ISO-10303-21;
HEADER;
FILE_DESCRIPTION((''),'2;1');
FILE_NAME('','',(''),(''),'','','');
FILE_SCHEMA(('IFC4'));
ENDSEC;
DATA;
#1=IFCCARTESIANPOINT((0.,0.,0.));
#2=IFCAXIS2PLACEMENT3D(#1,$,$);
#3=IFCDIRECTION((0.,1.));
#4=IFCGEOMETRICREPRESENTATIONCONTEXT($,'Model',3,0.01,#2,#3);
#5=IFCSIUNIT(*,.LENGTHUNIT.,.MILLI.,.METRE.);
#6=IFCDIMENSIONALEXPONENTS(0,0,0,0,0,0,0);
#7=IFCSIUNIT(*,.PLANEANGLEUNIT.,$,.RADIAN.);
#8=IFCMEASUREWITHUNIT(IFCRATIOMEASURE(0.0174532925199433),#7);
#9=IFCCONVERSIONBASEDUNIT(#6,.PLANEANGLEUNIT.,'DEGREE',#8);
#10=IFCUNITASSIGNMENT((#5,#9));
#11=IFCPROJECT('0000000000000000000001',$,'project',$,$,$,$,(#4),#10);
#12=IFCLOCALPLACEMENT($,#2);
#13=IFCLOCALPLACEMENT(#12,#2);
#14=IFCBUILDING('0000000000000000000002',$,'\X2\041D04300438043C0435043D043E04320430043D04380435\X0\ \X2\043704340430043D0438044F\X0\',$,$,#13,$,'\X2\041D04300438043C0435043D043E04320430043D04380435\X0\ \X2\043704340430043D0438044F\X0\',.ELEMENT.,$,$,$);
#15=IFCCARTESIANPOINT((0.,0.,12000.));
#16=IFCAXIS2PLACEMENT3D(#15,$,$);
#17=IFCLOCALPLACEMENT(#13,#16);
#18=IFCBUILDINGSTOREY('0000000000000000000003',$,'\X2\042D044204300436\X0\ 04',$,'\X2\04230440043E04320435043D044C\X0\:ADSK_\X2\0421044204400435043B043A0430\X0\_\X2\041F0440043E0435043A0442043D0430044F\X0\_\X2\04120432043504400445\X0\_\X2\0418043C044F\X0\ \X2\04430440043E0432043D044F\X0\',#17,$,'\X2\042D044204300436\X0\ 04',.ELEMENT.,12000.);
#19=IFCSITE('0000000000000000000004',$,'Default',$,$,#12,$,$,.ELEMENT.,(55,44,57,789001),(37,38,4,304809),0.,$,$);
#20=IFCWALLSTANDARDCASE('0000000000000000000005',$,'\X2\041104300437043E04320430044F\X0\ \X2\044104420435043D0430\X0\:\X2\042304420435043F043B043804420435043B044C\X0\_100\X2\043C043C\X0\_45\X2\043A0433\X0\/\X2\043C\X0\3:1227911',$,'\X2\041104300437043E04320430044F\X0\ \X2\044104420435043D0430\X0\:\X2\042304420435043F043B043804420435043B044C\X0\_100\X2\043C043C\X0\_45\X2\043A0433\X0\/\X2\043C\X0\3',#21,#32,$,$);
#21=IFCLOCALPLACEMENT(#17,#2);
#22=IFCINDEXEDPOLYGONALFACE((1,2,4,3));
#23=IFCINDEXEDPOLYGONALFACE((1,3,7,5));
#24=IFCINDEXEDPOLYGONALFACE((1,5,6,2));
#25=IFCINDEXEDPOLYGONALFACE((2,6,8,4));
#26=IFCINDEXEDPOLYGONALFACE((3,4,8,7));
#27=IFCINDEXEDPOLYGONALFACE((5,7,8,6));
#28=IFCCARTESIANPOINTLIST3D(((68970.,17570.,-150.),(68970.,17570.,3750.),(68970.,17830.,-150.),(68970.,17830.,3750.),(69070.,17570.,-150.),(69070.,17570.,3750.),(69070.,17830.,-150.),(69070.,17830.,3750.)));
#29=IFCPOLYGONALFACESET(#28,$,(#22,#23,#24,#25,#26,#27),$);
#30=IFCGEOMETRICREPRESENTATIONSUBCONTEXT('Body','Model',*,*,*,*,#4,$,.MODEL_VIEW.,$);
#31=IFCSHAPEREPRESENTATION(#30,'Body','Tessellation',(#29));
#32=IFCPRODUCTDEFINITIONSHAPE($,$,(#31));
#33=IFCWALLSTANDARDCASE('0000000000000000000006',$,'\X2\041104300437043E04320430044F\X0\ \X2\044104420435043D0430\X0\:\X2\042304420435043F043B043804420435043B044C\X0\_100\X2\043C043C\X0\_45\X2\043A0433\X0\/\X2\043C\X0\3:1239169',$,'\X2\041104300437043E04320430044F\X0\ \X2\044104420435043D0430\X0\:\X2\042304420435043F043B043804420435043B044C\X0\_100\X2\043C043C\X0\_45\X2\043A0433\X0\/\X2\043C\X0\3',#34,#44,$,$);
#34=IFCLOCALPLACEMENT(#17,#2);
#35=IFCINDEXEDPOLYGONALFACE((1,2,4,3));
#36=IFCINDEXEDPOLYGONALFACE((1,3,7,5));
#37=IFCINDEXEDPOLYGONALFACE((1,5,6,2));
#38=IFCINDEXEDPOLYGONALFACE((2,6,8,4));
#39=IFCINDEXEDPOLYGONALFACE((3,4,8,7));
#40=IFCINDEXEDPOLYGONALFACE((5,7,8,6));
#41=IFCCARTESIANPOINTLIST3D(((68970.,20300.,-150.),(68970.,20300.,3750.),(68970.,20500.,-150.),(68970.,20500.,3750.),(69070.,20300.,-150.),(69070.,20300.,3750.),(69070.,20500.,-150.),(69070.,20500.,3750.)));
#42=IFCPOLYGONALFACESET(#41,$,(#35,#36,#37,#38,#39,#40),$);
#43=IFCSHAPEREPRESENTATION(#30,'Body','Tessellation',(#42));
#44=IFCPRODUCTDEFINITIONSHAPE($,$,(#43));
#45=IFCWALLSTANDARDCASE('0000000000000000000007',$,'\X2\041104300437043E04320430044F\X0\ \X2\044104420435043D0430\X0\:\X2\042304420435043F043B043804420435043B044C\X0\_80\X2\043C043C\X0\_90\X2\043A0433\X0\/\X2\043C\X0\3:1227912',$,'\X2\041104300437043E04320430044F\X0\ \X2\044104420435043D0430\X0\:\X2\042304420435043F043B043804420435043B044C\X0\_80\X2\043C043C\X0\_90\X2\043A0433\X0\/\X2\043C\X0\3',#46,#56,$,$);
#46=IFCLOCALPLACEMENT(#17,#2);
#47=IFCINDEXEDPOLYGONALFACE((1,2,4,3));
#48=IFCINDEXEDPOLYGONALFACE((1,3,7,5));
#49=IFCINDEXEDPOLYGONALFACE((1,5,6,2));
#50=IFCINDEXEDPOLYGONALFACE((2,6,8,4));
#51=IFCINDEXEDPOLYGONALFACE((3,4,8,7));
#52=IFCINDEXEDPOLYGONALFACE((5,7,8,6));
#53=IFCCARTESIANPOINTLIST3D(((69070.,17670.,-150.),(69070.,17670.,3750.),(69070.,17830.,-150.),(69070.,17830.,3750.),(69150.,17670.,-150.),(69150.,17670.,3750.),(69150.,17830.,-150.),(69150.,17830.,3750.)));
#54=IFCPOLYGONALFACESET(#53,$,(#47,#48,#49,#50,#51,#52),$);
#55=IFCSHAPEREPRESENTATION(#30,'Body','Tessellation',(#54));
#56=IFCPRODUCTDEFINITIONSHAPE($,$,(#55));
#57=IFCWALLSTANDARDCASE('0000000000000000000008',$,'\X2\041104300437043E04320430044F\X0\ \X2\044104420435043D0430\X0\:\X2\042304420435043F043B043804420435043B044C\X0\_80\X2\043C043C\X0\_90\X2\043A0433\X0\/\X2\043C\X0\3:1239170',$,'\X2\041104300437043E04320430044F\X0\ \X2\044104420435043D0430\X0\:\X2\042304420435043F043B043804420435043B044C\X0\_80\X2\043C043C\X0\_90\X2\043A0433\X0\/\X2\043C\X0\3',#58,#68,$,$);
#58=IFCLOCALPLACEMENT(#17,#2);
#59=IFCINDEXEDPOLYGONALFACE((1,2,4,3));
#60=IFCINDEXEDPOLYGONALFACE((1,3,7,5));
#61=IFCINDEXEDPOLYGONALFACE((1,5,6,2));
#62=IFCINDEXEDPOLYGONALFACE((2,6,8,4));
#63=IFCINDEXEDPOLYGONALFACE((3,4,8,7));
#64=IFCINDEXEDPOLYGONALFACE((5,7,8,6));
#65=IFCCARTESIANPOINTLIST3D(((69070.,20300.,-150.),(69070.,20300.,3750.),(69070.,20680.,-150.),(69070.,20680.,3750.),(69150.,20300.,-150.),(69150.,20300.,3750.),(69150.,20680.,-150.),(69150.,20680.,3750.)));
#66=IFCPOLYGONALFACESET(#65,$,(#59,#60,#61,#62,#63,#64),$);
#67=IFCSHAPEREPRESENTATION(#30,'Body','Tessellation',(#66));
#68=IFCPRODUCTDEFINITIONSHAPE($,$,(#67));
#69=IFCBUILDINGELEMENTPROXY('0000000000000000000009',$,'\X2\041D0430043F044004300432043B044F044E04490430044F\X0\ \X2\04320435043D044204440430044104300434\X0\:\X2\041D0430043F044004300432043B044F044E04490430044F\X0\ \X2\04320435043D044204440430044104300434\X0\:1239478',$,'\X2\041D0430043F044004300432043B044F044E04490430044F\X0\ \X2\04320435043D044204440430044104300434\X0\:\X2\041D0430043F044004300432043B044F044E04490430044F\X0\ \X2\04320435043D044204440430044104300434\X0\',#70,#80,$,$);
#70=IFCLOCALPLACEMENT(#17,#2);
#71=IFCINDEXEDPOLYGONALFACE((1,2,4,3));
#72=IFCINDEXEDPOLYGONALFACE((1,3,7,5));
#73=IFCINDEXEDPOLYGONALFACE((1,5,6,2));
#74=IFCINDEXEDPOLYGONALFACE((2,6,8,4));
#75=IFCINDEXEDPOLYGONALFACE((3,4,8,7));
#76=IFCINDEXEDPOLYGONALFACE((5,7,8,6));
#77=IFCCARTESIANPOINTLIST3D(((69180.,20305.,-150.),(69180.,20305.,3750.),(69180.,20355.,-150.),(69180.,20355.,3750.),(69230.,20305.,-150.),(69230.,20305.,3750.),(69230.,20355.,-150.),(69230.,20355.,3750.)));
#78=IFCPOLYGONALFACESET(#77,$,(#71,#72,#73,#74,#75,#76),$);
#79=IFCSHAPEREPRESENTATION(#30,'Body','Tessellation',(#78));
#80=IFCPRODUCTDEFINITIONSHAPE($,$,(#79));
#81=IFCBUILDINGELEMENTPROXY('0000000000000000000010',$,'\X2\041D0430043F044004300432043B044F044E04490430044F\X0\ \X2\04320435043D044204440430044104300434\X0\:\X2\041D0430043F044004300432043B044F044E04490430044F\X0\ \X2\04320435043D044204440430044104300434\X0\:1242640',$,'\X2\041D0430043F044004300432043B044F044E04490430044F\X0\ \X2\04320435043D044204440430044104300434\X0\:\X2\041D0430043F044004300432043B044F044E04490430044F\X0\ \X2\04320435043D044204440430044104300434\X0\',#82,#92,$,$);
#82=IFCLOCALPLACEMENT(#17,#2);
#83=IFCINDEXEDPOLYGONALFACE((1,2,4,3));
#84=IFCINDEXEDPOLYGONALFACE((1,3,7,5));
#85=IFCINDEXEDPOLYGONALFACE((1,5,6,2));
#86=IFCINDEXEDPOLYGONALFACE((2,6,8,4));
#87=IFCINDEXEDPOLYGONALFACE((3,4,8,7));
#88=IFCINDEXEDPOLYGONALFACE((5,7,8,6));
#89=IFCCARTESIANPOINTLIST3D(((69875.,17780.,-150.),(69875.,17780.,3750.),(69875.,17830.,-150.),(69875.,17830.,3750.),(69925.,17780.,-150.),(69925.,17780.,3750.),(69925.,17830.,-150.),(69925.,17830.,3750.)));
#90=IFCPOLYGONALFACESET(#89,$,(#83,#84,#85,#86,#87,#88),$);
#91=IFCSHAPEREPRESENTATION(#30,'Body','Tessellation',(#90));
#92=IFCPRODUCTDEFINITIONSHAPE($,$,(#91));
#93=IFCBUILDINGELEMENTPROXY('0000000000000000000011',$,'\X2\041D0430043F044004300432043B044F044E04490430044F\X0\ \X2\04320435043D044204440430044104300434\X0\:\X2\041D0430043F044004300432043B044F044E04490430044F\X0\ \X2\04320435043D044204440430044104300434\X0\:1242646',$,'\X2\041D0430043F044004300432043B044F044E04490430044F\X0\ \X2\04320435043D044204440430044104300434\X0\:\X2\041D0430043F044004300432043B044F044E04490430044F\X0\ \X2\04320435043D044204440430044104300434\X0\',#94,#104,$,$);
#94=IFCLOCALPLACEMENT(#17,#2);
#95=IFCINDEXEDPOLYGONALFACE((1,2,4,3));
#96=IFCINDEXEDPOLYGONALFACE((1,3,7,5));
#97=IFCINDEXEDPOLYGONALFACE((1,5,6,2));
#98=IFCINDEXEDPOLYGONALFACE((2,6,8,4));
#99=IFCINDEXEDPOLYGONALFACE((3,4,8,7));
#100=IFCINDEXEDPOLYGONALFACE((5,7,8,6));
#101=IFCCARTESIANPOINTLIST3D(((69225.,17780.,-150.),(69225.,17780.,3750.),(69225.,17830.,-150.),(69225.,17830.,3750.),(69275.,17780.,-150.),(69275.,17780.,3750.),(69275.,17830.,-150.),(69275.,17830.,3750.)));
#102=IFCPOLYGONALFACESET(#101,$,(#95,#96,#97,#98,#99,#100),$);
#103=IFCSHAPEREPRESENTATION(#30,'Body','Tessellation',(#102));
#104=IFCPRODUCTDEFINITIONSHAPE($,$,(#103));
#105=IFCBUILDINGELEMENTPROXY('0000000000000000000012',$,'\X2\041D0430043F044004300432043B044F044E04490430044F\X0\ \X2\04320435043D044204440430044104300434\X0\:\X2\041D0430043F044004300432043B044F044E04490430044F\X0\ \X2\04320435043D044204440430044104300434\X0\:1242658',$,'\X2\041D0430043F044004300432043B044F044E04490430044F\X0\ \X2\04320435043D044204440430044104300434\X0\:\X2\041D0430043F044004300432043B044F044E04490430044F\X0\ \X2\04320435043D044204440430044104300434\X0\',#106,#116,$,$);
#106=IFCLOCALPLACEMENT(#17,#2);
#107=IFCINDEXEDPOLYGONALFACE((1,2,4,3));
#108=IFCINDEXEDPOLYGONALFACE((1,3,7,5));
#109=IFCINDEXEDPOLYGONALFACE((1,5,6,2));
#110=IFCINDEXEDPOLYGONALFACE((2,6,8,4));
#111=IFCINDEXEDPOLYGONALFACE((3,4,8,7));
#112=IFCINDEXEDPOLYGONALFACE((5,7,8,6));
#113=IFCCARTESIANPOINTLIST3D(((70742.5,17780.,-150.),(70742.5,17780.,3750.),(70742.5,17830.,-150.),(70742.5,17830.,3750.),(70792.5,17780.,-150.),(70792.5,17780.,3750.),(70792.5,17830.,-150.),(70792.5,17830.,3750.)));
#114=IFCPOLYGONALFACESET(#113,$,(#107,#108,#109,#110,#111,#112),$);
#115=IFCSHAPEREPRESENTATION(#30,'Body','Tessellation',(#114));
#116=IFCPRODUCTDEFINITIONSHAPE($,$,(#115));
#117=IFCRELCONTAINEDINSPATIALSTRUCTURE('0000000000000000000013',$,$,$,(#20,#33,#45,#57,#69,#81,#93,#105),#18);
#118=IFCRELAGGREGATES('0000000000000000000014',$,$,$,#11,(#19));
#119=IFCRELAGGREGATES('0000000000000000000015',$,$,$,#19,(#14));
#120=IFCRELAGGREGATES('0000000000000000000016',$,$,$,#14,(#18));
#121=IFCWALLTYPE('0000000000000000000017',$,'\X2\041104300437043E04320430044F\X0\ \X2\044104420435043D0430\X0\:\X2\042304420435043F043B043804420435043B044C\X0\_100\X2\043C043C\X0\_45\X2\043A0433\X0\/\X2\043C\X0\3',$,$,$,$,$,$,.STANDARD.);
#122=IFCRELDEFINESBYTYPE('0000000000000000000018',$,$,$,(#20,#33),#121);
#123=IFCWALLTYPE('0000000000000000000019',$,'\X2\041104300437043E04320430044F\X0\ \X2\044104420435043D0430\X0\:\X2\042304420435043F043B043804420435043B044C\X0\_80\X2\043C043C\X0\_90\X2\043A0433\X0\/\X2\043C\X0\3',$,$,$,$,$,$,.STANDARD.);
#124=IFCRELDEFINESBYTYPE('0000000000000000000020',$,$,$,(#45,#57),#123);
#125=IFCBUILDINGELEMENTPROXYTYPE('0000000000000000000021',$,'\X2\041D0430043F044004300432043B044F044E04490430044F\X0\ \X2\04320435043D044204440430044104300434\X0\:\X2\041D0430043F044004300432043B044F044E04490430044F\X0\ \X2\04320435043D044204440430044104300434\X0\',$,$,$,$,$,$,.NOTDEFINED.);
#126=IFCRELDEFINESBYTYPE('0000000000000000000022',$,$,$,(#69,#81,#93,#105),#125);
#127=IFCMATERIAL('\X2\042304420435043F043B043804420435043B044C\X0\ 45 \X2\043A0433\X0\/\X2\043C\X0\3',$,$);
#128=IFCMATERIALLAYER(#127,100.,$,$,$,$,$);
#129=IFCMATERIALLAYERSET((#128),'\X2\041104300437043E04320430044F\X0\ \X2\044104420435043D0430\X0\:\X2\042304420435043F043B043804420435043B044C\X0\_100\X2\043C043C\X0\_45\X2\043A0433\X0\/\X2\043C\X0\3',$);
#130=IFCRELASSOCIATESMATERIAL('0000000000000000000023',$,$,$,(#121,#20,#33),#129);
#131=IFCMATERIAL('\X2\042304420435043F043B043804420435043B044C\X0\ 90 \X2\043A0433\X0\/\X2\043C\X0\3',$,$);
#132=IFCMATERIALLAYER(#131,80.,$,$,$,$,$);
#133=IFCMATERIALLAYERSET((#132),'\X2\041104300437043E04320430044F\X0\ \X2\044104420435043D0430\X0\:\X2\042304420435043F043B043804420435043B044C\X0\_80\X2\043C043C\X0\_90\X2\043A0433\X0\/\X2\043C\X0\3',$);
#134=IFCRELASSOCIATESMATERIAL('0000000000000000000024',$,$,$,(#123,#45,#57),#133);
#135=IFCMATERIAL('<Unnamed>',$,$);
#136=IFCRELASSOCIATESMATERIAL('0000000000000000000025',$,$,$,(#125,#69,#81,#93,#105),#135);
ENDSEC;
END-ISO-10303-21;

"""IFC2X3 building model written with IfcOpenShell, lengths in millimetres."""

from ifc_helpers import new_model, entity, si_unit, converted_unit, direction, frame, frame_2d, origin, origin_2d_with_axis, place, context, subcontext, project, spatial, rectangle, extrude, source, transform, mapped, material, layer, layer_set, layer_usage, type_object, type_shapes, element, save


model = new_model("IFC2X3")

# Units and contexts
model_context = context("Model", 3, precision=0.01, world=origin(), true_north=direction((0.0, 1.0)))
body_context = subcontext(model_context, "Body", "Model", "MODEL_VIEW")
ifc_project = project(units=[si_unit("LENGTHUNIT", "METRE", prefix="MILLI"), converted_unit("PLANEANGLEUNIT", "DEGREE", entity("IfcRatioMeasure", 0.0174532925199433), si_unit("PLANEANGLEUNIT", "RADIAN"), dimensions=[0, 0, 0, 0, 0, 0, 0])], contexts=[model_context])

# Site, building, storey
site_placement = place(None, origin())
site = spatial("IfcSite", under=ifc_project, at=site_placement, Name="Default", CompositionType="ELEMENT", RefLatitude=(55, 44, 57, 789001), RefLongitude=(37, 38, 4, 304809), RefElevation=0.0)
building_placement = place(site_placement, origin())
building = spatial("IfcBuilding", under=site, at=building_placement, Name="Наименование здания", LongName="Наименование здания", CompositionType="ELEMENT")
storey_placement = place(building_placement, frame((0.0, 0.0, 12000.0)))
storey = spatial("IfcBuildingStorey", under=building, at=storey_placement, Name="Этаж 04", ObjectType="Уровень:ADSK_Стрелка_Проектная_Вверх_Имя уровня", LongName="Этаж 04", CompositionType="ELEMENT", Elevation=12000.0)

# Walls
ifc_material_1 = material(Name="Утеплитель 45 кг/м3")
ifc_layer_1 = layer(ifc_material_1, 100.0)
ifc_layer_set_1 = layer_set([ifc_layer_1], Name="Базовая стена:Утеплитель_100мм_45кг/м3")
ifc_layer_usage_1 = layer_usage(ifc_layer_set_1, "AXIS2", "NEGATIVE", 50.0)
wall_type_1 = type_object("IfcWallType", Name="Базовая стена:Утеплитель_100мм_45кг/м3", PredefinedType="STANDARD", material=ifc_layer_set_1)
wall_1_placement = place(storey_placement, frame((69020.0, 17830.0, -150.0), z_axis=(0.0, 0.0, 1.0), x_axis=(0.0, -1.0, 0.0)))
element("IfcWallStandardCase", 1, at=wall_1_placement, inside=storey, type_object=wall_type_1, material=ifc_layer_usage_1, Name="Базовая стена:Утеплитель_100мм_45кг/м3:1227911", ObjectType="Базовая стена:Утеплитель_100мм_45кг/м3", context=body_context, shape_type="SweptSolid", body=[
    extrude(rectangle(XDim=260.0, YDim=100.0, at=frame_2d((130.0, 0.0), x_axis=(-1.0, 0.0))), origin(), (0.0, 0.0, 1.0), 3900.0),
])
ifc_layer_usage_2 = layer_usage(ifc_layer_set_1, "AXIS2", "POSITIVE", -50.0)
wall_2_placement = place(storey_placement, frame((69020.0, 20300.0, -150.0), z_axis=(0.0, 0.0, 1.0), x_axis=(0.0, 1.0, 0.0)))
element("IfcWallStandardCase", 2, at=wall_2_placement, inside=storey, type_object=wall_type_1, material=ifc_layer_usage_2, Name="Базовая стена:Утеплитель_100мм_45кг/м3:1239169", ObjectType="Базовая стена:Утеплитель_100мм_45кг/м3", context=body_context, shape_type="SweptSolid", body=[
    extrude(rectangle(XDim=200.0, YDim=100.0, at=frame_2d((100.0, 0.0), x_axis=(-1.0, 0.0))), origin(), (0.0, 0.0, 1.0), 3900.0),
])
ifc_material_2 = material(Name="Утеплитель 90 кг/м3")
ifc_layer_2 = layer(ifc_material_2, 80.0)
ifc_layer_set_2 = layer_set([ifc_layer_2], Name="Базовая стена:Утеплитель_80мм_90кг/м3")
ifc_layer_usage_3 = layer_usage(ifc_layer_set_2, "AXIS2", "NEGATIVE", 40.0)
wall_type_2 = type_object("IfcWallType", Name="Базовая стена:Утеплитель_80мм_90кг/м3", PredefinedType="STANDARD", material=ifc_layer_set_2)
wall_3_placement = place(storey_placement, frame((69110.0, 17830.0, -150.0), z_axis=(0.0, 0.0, 1.0), x_axis=(0.0, -1.0, 0.0)))
element("IfcWallStandardCase", 3, at=wall_3_placement, inside=storey, type_object=wall_type_2, material=ifc_layer_usage_3, Name="Базовая стена:Утеплитель_80мм_90кг/м3:1227912", ObjectType="Базовая стена:Утеплитель_80мм_90кг/м3", context=body_context, shape_type="SweptSolid", body=[
    extrude(rectangle(XDim=160.0, YDim=80.0, at=frame_2d((80.0, 0.0), x_axis=(-1.0, 0.0))), origin(), (0.0, 0.0, 1.0), 3900.0),
])
ifc_layer_usage_4 = layer_usage(ifc_layer_set_2, "AXIS2", "POSITIVE", -40.0)
wall_4_placement = place(storey_placement, frame((69110.0, 20300.0, -150.0), z_axis=(0.0, 0.0, 1.0), x_axis=(0.0, 1.0, 0.0)))
element("IfcWallStandardCase", 4, at=wall_4_placement, inside=storey, type_object=wall_type_2, material=ifc_layer_usage_4, Name="Базовая стена:Утеплитель_80мм_90кг/м3:1239170", ObjectType="Базовая стена:Утеплитель_80мм_90кг/м3", context=body_context, shape_type="SweptSolid", body=[
    extrude(rectangle(XDim=380.0, YDim=80.0, at=frame_2d((190.0, 0.0), x_axis=(-1.0, 0.0))), origin(), (0.0, 0.0, 1.0), 3900.0),
])

# Building element proxies
ifc_material_3 = material(Name="<Unnamed>")
building_element_proxy_type_1 = type_object("IfcBuildingElementProxyType", Name="Направляющая вентфасад:Направляющая вентфасад", PredefinedType="NOTDEFINED", material=ifc_material_3)
shared_shape_1 = source(origin(), body_context, "Body", "SweptSolid", [
    extrude(rectangle(XDim=50.0, YDim=50.0, at=origin_2d_with_axis()), frame((25.0, -25.0, 0.0), z_axis=(0.0, 0.0, 1.0), x_axis=(-1.0, 0.0, 0.0)), (0.0, 0.0, 1.0), 3900.0),
])
type_shapes(building_element_proxy_type_1, [shared_shape_1])
for number, where, z_axis, x_axis, name in (
    (5, (69180.0, 20305.0, -150.0), (0.0, 0.0, 1.0), (0.0, 1.0, 0.0), "Направляющая вентфасад:Направляющая вентфасад:1239478"),
    (6, (69925.0, 17780.0, -150.0), (0.0, 0.0, 1.0), (-1.0, 0.0, 0.0), "Направляющая вентфасад:Направляющая вентфасад:1242640"),
    (7, (69275.0, 17780.0, -150.0), (0.0, 0.0, 1.0), (-1.0, 0.0, 0.0), "Направляющая вентфасад:Направляющая вентфасад:1242646"),
    (8, (70792.5, 17780.0, -150.0), (0.0, 0.0, 1.0), (-1.0, 0.0, 0.0), "Направляющая вентфасад:Направляющая вентфасад:1242658"),
):
    element("IfcBuildingElementProxy", number, at=place(storey_placement, frame(where, z_axis=z_axis, x_axis=x_axis)), inside=storey, type_object=building_element_proxy_type_1, material=ifc_material_3, Name=name, ObjectType="Направляющая вентфасад:Направляющая вентфасад", context=body_context, shape_type="MappedRepresentation", body=[
        mapped(shared_shape_1, transform((0.0, 0.0, 0.0), scale=1.0)),
    ])

save(model, "model.ifc")
